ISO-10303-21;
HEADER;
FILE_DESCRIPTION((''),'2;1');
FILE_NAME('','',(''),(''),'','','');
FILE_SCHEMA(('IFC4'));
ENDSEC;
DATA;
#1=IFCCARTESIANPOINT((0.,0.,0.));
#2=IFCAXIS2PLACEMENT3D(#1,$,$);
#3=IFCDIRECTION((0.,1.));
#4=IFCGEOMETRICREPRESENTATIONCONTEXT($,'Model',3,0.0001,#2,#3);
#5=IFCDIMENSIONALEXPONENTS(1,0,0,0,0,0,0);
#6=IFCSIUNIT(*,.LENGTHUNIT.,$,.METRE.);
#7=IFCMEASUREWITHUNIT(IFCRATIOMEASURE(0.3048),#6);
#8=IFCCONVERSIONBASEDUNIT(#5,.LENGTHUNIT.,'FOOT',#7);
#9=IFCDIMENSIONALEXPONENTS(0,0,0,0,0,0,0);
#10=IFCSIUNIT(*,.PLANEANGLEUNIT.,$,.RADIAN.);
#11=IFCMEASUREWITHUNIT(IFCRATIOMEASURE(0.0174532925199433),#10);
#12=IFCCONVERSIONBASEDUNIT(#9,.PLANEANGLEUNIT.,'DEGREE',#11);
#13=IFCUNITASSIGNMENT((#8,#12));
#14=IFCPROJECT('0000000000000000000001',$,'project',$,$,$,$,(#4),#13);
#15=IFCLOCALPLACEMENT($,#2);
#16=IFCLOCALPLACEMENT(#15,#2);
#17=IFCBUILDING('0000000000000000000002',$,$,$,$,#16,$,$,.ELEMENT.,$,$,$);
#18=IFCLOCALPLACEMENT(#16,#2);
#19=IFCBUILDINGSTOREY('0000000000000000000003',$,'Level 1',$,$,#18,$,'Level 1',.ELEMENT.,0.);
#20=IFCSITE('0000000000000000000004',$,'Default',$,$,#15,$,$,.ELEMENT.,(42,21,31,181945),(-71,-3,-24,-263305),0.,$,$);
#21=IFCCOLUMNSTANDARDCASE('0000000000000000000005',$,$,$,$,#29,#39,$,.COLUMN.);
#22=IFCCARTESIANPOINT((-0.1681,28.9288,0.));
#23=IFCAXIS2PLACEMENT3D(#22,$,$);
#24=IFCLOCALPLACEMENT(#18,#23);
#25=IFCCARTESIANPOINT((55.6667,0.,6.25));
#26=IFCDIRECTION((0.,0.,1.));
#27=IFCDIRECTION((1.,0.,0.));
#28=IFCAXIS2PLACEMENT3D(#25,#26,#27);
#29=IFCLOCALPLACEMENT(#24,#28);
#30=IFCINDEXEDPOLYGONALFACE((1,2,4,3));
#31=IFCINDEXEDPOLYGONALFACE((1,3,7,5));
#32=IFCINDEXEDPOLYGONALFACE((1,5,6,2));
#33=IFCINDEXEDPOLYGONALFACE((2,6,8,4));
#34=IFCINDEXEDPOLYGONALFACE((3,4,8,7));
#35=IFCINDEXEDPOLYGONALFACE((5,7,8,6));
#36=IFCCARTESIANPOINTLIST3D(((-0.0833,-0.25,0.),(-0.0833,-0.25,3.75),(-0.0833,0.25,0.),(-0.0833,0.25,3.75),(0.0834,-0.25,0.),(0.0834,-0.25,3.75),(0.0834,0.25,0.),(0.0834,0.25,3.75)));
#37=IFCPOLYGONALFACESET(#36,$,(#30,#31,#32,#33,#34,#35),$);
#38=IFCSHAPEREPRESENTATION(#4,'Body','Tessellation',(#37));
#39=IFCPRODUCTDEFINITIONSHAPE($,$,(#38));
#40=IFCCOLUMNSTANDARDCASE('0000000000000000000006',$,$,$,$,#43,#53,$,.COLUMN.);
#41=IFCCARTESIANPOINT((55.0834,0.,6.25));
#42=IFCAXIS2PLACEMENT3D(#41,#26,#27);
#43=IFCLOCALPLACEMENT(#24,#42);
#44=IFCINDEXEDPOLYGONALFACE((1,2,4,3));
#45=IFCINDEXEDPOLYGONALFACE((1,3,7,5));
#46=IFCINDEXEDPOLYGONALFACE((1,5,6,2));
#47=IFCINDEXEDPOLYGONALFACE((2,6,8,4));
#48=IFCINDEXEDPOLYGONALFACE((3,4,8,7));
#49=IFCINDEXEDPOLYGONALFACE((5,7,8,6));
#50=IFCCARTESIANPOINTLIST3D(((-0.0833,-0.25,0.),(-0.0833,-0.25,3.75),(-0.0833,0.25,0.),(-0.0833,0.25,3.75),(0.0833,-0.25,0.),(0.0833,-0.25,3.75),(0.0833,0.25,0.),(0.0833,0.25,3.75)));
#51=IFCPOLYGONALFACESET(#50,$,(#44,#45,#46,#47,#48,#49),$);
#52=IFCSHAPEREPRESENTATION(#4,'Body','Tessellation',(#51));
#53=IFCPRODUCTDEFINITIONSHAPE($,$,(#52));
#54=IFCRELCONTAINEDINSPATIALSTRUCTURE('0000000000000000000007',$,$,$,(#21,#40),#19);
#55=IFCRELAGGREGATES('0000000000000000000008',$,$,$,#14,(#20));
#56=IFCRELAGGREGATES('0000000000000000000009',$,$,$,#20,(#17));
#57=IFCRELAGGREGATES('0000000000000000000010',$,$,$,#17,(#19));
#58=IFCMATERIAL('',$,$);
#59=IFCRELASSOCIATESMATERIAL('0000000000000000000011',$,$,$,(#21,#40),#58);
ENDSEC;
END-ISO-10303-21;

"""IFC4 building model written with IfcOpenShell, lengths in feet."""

from ifc_helpers import new_model, entity, si_unit, converted_unit, direction, frame, origin, place, context, project, spatial, rectangle, extrude, material, element, save


model = new_model("IFC4")

# Units and contexts
model_context = context("Model", 3, precision=0.0001, world=origin(), true_north=direction((0.0, 1.0)))
ifc_project = project(units=[converted_unit("LENGTHUNIT", "FOOT", entity("IfcRatioMeasure", 0.3048), si_unit("LENGTHUNIT", "METRE"), dimensions=[1, 0, 0, 0, 0, 0, 0]), converted_unit("PLANEANGLEUNIT", "DEGREE", entity("IfcRatioMeasure", 0.0174532925199433), si_unit("PLANEANGLEUNIT", "RADIAN"), dimensions=[0, 0, 0, 0, 0, 0, 0])], contexts=[model_context])

# Site, building, storey
site_placement = place(None, origin())
site = spatial("IfcSite", under=ifc_project, at=site_placement, Name="Default", CompositionType="ELEMENT", RefLatitude=(42, 21, 31, 181945), RefLongitude=(-71, -3, -24, -263305), RefElevation=0.0)
building_placement = place(site_placement, origin())
building = spatial("IfcBuilding", under=site, at=building_placement, CompositionType="ELEMENT")
storey_placement = place(building_placement, origin())
storey = spatial("IfcBuildingStorey", under=building, at=storey_placement, Name="Level 1", LongName="Level 1", CompositionType="ELEMENT", Elevation=0.0)

# Columns
ifc_material_1 = material(Name="")
placement = place(storey_placement, frame((-0.1681, 28.9288, 0.0)))
for number, where, z_axis, x_axis in (
    (1, (55.6667, 0.0, 6.25), (0.0, 0.0, 1.0), (1.0, 0.0, 0.0)),
    (2, (55.0834, 0.0, 6.25), (0.0, 0.0, 1.0), (1.0, 0.0, 0.0)),
):
    element("IfcColumnStandardCase", number, at=place(placement, frame(where, z_axis=z_axis, x_axis=x_axis)), inside=storey, material=ifc_material_1, PredefinedType="COLUMN", context=model_context, shape_type="SweptSolid", body=[
        extrude(rectangle(XDim=0.1667, YDim=0.5), origin(), (0.0, 0.0, 1.0), 3.75),
    ])

save(model, "model.ifc")
